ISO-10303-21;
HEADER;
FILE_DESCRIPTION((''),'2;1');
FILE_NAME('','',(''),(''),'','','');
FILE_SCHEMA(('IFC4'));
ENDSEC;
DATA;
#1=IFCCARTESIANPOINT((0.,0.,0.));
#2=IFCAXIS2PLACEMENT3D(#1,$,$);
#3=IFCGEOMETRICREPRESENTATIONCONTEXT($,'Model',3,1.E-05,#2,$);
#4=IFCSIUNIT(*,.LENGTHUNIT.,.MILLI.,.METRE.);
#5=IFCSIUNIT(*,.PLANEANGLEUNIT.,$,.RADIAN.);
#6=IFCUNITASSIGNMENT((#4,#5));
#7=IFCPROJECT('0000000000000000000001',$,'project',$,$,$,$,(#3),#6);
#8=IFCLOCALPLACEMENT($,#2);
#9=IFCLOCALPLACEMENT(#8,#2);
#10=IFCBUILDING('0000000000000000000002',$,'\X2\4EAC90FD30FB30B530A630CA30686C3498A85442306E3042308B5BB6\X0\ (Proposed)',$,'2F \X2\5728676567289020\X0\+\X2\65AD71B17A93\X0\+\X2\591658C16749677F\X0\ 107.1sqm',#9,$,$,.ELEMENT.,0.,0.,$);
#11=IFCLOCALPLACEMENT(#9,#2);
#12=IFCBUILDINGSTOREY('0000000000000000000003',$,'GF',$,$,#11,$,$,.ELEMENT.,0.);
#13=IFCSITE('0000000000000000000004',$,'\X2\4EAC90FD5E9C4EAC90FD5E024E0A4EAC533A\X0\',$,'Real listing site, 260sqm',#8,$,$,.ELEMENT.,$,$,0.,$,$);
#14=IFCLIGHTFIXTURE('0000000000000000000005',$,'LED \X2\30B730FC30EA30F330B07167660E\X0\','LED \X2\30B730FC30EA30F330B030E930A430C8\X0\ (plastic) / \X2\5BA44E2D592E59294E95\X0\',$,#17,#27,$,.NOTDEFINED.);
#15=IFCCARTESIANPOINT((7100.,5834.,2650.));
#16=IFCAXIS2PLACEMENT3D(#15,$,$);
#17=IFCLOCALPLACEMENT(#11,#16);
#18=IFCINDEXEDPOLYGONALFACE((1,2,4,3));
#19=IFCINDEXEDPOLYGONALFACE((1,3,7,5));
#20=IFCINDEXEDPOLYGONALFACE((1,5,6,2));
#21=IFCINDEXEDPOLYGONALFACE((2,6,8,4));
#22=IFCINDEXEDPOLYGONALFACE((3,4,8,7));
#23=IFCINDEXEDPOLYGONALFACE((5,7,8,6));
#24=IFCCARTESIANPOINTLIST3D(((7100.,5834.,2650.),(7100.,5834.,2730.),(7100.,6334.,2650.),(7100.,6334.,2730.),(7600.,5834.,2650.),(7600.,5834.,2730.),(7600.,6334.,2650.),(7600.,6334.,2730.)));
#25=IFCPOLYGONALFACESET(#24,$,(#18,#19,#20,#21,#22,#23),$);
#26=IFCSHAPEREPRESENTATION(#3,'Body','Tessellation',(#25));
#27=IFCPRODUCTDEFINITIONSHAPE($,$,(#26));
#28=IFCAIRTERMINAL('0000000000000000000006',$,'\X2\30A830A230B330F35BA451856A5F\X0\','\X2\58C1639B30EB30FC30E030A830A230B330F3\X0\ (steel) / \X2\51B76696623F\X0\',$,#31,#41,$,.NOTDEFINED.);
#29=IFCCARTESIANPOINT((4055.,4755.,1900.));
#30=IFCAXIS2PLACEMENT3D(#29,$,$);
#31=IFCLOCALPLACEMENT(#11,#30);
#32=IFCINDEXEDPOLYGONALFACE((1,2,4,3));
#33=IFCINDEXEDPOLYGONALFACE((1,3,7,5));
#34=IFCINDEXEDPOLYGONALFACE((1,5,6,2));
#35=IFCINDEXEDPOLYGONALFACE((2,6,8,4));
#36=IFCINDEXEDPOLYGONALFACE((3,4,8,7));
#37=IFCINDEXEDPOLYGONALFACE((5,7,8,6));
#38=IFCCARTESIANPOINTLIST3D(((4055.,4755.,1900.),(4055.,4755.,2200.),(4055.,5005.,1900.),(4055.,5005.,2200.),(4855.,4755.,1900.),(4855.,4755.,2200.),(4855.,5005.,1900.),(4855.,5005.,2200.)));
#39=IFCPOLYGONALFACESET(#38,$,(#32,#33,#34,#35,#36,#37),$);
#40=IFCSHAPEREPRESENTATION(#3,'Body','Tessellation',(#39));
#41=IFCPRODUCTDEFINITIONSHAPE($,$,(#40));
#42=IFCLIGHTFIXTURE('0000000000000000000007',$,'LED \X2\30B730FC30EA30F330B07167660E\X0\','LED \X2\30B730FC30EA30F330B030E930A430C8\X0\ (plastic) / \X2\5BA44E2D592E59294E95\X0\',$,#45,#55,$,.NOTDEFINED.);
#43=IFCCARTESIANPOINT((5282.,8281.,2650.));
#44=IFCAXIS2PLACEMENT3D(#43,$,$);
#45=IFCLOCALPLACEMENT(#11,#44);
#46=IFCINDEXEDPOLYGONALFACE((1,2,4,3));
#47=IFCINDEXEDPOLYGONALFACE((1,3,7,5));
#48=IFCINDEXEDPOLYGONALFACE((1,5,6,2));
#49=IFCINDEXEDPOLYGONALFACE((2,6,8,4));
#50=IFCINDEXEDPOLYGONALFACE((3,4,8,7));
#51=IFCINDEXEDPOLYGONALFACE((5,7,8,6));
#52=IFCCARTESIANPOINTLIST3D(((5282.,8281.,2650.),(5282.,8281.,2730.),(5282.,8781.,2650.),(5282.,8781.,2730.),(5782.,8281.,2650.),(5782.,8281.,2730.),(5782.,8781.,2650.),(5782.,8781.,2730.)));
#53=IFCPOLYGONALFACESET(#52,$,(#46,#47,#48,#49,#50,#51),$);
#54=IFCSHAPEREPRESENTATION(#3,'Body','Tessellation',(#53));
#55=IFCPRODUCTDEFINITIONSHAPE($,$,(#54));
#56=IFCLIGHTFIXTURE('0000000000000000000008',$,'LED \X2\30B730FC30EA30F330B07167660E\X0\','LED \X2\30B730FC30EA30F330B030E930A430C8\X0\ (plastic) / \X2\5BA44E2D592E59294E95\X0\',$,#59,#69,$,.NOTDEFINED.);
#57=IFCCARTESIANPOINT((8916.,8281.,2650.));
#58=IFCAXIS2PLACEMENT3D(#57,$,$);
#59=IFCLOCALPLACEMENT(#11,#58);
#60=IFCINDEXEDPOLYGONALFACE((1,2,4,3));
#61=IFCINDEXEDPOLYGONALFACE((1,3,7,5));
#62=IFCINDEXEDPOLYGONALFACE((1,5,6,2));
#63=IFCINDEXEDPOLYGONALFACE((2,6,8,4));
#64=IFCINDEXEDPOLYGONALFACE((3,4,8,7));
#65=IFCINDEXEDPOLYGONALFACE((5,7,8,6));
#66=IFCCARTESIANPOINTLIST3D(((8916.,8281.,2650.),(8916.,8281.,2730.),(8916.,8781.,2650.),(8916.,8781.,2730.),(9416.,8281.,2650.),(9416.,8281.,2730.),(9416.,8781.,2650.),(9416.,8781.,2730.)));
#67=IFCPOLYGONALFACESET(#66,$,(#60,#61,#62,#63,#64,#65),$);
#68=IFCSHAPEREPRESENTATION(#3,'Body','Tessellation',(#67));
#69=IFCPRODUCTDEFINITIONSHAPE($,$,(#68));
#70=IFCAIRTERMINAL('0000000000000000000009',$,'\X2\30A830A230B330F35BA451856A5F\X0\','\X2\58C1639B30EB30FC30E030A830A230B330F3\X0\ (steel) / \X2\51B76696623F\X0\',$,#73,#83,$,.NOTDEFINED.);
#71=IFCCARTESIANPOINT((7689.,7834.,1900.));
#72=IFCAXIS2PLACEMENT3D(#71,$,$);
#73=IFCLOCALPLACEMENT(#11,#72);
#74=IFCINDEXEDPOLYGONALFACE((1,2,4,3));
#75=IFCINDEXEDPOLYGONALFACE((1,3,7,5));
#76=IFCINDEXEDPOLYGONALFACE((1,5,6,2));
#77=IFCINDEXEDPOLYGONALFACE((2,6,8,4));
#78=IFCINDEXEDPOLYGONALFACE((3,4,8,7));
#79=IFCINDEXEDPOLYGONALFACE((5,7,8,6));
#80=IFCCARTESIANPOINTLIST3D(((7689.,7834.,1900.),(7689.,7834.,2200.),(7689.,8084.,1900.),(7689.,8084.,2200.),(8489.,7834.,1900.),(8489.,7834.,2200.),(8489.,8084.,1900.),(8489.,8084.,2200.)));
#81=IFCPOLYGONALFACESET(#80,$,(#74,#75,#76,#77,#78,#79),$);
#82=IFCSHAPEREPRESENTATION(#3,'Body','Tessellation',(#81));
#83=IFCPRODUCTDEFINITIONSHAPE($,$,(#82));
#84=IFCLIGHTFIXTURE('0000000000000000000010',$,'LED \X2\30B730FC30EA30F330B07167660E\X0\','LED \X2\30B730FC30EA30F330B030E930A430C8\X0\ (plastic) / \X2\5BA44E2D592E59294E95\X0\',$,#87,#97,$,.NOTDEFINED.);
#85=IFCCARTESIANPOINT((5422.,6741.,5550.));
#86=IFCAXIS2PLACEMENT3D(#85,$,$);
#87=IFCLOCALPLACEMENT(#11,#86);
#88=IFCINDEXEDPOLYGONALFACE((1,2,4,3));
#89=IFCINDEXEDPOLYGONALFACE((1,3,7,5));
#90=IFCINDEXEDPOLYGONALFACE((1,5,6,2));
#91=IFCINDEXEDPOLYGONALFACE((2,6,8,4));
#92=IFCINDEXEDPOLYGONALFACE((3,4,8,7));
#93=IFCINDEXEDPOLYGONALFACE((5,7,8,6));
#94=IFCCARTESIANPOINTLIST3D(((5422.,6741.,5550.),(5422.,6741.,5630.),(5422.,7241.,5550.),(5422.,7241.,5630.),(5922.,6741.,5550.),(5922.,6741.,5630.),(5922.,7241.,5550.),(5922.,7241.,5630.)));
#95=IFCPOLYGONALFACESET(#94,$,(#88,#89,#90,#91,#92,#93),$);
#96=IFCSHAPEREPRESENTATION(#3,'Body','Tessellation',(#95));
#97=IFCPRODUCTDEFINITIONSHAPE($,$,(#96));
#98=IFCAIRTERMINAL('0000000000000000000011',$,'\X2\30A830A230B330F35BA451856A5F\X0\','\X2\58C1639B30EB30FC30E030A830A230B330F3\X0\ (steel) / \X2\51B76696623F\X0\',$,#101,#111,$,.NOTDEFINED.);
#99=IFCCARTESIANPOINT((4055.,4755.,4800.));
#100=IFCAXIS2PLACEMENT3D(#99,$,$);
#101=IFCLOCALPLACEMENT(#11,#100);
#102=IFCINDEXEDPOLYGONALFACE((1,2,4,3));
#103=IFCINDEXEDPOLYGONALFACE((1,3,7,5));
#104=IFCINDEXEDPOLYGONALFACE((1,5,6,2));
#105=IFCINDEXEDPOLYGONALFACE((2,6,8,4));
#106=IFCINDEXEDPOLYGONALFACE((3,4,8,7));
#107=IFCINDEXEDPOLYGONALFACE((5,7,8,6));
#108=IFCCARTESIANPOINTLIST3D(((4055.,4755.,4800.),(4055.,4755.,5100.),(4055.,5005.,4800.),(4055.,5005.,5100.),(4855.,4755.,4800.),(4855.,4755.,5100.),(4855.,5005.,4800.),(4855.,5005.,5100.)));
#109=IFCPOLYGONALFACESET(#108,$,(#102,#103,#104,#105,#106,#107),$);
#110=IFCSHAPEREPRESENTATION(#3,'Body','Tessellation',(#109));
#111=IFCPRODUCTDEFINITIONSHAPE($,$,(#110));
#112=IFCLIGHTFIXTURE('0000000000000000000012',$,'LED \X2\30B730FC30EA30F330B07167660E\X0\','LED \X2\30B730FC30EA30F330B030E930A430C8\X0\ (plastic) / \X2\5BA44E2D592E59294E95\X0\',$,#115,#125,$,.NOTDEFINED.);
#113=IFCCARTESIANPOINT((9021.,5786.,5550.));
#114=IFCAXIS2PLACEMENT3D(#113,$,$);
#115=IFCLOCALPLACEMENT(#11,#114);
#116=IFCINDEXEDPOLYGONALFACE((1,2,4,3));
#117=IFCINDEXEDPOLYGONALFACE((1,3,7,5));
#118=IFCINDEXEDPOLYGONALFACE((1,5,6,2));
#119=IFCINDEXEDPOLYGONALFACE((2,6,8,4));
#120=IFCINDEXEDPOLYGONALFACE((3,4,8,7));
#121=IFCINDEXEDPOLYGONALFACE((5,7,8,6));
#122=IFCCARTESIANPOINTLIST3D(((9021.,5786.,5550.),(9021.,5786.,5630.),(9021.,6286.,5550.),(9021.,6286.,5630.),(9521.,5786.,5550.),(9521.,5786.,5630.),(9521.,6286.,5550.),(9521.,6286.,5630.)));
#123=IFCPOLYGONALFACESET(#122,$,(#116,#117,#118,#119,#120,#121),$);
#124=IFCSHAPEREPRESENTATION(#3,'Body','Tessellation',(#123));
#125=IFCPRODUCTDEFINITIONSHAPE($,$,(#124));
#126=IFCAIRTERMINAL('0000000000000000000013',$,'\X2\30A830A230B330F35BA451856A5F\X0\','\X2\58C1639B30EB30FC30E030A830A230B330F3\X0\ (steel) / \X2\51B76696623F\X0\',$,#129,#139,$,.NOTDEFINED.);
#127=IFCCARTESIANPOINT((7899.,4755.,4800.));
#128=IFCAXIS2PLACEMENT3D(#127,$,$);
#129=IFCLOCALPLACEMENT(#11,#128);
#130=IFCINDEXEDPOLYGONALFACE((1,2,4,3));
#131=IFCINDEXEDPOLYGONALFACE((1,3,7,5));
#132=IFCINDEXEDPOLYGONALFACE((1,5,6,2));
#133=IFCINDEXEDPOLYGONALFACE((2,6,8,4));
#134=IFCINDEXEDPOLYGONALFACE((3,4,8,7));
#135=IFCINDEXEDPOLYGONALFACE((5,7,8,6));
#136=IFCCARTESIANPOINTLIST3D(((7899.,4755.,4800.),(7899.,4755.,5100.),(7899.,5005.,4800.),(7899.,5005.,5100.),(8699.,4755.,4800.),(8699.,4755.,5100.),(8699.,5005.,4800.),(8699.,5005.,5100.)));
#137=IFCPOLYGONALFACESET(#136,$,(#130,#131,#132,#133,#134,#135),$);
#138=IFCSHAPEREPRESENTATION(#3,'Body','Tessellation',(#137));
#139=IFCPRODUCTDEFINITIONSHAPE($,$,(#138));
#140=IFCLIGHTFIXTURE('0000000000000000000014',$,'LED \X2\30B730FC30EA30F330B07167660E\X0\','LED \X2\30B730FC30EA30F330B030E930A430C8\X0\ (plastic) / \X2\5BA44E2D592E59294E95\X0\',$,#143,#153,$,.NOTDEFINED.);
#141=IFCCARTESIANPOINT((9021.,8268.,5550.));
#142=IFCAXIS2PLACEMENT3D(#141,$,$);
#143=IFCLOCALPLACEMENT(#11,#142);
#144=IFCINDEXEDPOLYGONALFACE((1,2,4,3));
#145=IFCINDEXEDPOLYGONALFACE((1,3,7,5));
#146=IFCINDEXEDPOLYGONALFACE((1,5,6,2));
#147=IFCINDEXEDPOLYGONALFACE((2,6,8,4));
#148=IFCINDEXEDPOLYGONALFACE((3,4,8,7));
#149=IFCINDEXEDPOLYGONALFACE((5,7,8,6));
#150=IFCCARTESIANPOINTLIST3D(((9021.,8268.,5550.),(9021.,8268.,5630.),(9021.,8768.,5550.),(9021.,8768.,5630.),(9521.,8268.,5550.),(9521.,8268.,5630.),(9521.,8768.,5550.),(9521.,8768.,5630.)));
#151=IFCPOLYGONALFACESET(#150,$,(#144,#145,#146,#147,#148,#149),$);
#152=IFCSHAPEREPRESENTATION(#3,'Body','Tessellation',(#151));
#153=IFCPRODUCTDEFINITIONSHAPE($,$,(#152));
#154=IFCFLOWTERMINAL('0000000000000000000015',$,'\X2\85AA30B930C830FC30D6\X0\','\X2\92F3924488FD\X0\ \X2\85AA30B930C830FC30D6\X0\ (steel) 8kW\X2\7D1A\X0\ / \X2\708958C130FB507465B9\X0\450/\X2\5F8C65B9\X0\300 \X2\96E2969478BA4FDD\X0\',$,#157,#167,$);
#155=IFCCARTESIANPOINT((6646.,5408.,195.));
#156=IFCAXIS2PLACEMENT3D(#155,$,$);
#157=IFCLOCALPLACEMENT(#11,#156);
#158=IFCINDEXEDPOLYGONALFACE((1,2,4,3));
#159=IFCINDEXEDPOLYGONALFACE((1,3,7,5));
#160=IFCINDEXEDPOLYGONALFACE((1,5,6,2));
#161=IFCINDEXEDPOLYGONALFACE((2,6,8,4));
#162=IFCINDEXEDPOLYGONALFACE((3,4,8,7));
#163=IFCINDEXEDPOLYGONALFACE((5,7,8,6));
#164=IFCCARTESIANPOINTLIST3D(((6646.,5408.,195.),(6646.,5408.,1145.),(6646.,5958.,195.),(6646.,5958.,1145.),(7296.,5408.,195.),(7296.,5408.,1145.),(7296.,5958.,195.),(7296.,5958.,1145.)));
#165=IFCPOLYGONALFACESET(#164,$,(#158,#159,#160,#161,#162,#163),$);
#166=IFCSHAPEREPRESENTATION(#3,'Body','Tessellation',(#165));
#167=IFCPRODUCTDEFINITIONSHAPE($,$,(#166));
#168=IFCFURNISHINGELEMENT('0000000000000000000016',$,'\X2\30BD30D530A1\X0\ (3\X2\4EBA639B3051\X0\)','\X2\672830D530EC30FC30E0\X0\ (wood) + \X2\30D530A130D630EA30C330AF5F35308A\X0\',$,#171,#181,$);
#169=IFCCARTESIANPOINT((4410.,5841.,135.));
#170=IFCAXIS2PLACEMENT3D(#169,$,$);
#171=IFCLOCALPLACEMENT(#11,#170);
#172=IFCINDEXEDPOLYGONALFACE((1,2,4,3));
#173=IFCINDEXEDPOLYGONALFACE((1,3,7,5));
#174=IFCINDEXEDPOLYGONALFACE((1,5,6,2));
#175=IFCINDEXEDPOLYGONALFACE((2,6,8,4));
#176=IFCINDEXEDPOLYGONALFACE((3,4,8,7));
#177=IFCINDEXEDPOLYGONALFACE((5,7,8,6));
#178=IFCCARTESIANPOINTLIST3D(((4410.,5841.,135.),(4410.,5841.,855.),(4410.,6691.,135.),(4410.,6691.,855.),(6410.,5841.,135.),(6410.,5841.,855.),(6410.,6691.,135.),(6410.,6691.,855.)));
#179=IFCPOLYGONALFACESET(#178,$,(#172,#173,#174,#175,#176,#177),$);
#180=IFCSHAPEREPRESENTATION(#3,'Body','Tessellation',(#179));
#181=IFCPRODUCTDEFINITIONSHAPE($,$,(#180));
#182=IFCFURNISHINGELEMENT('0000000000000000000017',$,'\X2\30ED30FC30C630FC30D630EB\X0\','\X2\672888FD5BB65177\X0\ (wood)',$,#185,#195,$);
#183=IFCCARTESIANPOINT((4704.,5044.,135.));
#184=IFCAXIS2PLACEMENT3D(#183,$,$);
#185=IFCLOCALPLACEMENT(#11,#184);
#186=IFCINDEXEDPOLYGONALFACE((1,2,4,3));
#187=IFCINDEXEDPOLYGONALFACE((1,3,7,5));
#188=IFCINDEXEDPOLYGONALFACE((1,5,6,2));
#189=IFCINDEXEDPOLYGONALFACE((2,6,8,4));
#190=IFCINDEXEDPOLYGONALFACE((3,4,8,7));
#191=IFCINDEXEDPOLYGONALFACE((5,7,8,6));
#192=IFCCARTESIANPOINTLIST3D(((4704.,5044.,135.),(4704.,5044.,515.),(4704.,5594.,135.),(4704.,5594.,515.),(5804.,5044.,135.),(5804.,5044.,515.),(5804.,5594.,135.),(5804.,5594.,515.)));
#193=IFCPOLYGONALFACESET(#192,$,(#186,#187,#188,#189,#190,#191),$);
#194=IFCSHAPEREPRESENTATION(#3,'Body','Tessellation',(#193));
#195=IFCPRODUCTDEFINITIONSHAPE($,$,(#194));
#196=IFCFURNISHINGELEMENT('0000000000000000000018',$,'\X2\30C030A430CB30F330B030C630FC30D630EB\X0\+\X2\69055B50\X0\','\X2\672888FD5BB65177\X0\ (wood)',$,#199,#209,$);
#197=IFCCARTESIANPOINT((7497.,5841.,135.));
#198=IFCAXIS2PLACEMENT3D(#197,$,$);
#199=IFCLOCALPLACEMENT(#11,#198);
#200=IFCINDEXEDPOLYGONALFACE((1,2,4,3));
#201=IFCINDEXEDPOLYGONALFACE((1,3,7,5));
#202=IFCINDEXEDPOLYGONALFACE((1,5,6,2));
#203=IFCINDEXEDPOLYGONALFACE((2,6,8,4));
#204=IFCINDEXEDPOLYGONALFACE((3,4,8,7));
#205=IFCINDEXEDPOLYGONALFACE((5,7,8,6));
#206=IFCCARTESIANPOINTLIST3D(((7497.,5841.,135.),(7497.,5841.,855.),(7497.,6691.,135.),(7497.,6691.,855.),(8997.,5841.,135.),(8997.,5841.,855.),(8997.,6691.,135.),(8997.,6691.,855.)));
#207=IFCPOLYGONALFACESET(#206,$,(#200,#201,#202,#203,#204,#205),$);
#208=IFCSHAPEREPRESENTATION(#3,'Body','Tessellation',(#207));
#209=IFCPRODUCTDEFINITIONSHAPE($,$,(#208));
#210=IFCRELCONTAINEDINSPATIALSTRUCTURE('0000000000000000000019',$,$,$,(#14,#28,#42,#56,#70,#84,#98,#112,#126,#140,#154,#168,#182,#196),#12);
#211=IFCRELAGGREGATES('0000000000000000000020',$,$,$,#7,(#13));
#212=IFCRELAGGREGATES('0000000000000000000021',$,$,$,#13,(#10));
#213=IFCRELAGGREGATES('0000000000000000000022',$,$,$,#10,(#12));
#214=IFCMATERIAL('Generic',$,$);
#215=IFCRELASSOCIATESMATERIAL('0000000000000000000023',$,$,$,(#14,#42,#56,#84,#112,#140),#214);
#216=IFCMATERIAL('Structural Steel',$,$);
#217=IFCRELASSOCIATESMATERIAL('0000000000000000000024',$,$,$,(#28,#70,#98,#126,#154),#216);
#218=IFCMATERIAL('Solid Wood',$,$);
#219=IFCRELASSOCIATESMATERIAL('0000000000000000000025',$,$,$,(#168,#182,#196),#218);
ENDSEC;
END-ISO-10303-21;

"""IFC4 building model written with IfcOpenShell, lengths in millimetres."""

from ifc_helpers import new_model, si_unit, frame, frame_2d, origin, place, context, project, spatial, rectangle, extrude, material, element, save


model = new_model("IFC4")

# Units and contexts
model_context = context("Model", 3, precision=1e-05, world=origin())
ifc_project = project(units=[si_unit("LENGTHUNIT", "METRE", prefix="MILLI"), si_unit("PLANEANGLEUNIT", "RADIAN")], contexts=[model_context])

# Site, building, storey
site_placement = place(None, origin())
site = spatial("IfcSite", under=ifc_project, at=site_placement, Name="京都府京都市上京区", ObjectType="Real listing site, 260sqm", CompositionType="ELEMENT", RefElevation=0.0)
building_placement = place(site_placement, origin())
building = spatial("IfcBuilding", under=site, at=building_placement, Name="京都・サウナと水風呂のある家 (Proposed)", ObjectType="2F 在来木造+断熱窓+外壁杉板 107.1sqm", CompositionType="ELEMENT", ElevationOfRefHeight=0.0, ElevationOfTerrain=0.0)
storey_placement = place(building_placement, origin())
storey = spatial("IfcBuildingStorey", under=building, at=storey_placement, Name="GF", CompositionType="ELEMENT", Elevation=0.0)

# Shared definitions
ifc_material_1 = material(Name="Solid Wood")

# Shared definitions
ifc_material_2 = material(Name="Structural Steel")

# Shared definitions
ifc_material_3 = material(Name="Generic")

# Light fixture
light_fixture_1_placement = place(storey_placement, frame((7100.0, 5834.0, 2650.0)))
element("IfcLightFixture", 1, at=light_fixture_1_placement, inside=storey, material=ifc_material_3, Name="LED シーリング照明", Description="LED シーリングライト (plastic) / 室中央天井", PredefinedType="NOTDEFINED", context=model_context, shape_type="SweptSolid", body=[
    extrude(rectangle(XDim=500.0, YDim=500.0, at=frame_2d((250.0, 250.0))), frame((7100.0, 5834.0, 2650.0)), (0.0, 0.0, 1.0), 80.0),
])

# Air terminal
air_terminal_1_placement = place(storey_placement, frame((4055.0, 4755.0, 1900.0)))
element("IfcAirTerminal", 2, at=air_terminal_1_placement, inside=storey, material=ifc_material_2, Name="エアコン室内機", Description="壁掛ルームエアコン (steel) / 冷暖房", PredefinedType="NOTDEFINED", context=model_context, shape_type="SweptSolid", body=[
    extrude(rectangle(XDim=800.0, YDim=250.0, at=frame_2d((400.0, 125.0))), frame((4055.0, 4755.0, 1900.0)), (0.0, 0.0, 1.0), 300.0),
])

# Light fixtures
light_fixture_2_placement = place(storey_placement, frame((5282.0, 8281.0, 2650.0)))
element("IfcLightFixture", 3, at=light_fixture_2_placement, inside=storey, material=ifc_material_3, Name="LED シーリング照明", Description="LED シーリングライト (plastic) / 室中央天井", PredefinedType="NOTDEFINED", context=model_context, shape_type="SweptSolid", body=[
    extrude(rectangle(XDim=500.0, YDim=500.0, at=frame_2d((250.0, 250.0))), frame((5282.0, 8281.0, 2650.0)), (0.0, 0.0, 1.0), 80.0),
])
light_fixture_3_placement = place(storey_placement, frame((8916.0, 8281.0, 2650.0)))
element("IfcLightFixture", 4, at=light_fixture_3_placement, inside=storey, material=ifc_material_3, Name="LED シーリング照明", Description="LED シーリングライト (plastic) / 室中央天井", PredefinedType="NOTDEFINED", context=model_context, shape_type="SweptSolid", body=[
    extrude(rectangle(XDim=500.0, YDim=500.0, at=frame_2d((250.0, 250.0))), frame((8916.0, 8281.0, 2650.0)), (0.0, 0.0, 1.0), 80.0),
])

# Air terminal
air_terminal_2_placement = place(storey_placement, frame((7689.0, 7834.0, 1900.0)))
element("IfcAirTerminal", 5, at=air_terminal_2_placement, inside=storey, material=ifc_material_2, Name="エアコン室内機", Description="壁掛ルームエアコン (steel) / 冷暖房", PredefinedType="NOTDEFINED", context=model_context, shape_type="SweptSolid", body=[
    extrude(rectangle(XDim=800.0, YDim=250.0, at=frame_2d((400.0, 125.0))), frame((7689.0, 7834.0, 1900.0)), (0.0, 0.0, 1.0), 300.0),
])

# Light fixture
light_fixture_4_placement = place(storey_placement, frame((5422.0, 6741.0, 5550.0)))
element("IfcLightFixture", 6, at=light_fixture_4_placement, inside=storey, material=ifc_material_3, Name="LED シーリング照明", Description="LED シーリングライト (plastic) / 室中央天井", PredefinedType="NOTDEFINED", context=model_context, shape_type="SweptSolid", body=[
    extrude(rectangle(XDim=500.0, YDim=500.0, at=frame_2d((250.0, 250.0))), frame((5422.0, 6741.0, 5550.0)), (0.0, 0.0, 1.0), 80.0),
])

# Air terminal
air_terminal_3_placement = place(storey_placement, frame((4055.0, 4755.0, 4800.0)))
element("IfcAirTerminal", 7, at=air_terminal_3_placement, inside=storey, material=ifc_material_2, Name="エアコン室内機", Description="壁掛ルームエアコン (steel) / 冷暖房", PredefinedType="NOTDEFINED", context=model_context, shape_type="SweptSolid", body=[
    extrude(rectangle(XDim=800.0, YDim=250.0, at=frame_2d((400.0, 125.0))), frame((4055.0, 4755.0, 4800.0)), (0.0, 0.0, 1.0), 300.0),
])

# Light fixture
light_fixture_5_placement = place(storey_placement, frame((9021.0, 5786.0, 5550.0)))
element("IfcLightFixture", 8, at=light_fixture_5_placement, inside=storey, material=ifc_material_3, Name="LED シーリング照明", Description="LED シーリングライト (plastic) / 室中央天井", PredefinedType="NOTDEFINED", context=model_context, shape_type="SweptSolid", body=[
    extrude(rectangle(XDim=500.0, YDim=500.0, at=frame_2d((250.0, 250.0))), frame((9021.0, 5786.0, 5550.0)), (0.0, 0.0, 1.0), 80.0),
])

# Air terminal
air_terminal_4_placement = place(storey_placement, frame((7899.0, 4755.0, 4800.0)))
element("IfcAirTerminal", 9, at=air_terminal_4_placement, inside=storey, material=ifc_material_2, Name="エアコン室内機", Description="壁掛ルームエアコン (steel) / 冷暖房", PredefinedType="NOTDEFINED", context=model_context, shape_type="SweptSolid", body=[
    extrude(rectangle(XDim=800.0, YDim=250.0, at=frame_2d((400.0, 125.0))), frame((7899.0, 4755.0, 4800.0)), (0.0, 0.0, 1.0), 300.0),
])

# Light fixture
light_fixture_6_placement = place(storey_placement, frame((9021.0, 8268.0, 5550.0)))
element("IfcLightFixture", 10, at=light_fixture_6_placement, inside=storey, material=ifc_material_3, Name="LED シーリング照明", Description="LED シーリングライト (plastic) / 室中央天井", PredefinedType="NOTDEFINED", context=model_context, shape_type="SweptSolid", body=[
    extrude(rectangle(XDim=500.0, YDim=500.0, at=frame_2d((250.0, 250.0))), frame((9021.0, 8268.0, 5550.0)), (0.0, 0.0, 1.0), 80.0),
])

# Flow terminal
flow_terminal_1_placement = place(storey_placement, frame((6646.0, 5408.0, 195.0)))
element("IfcFlowTerminal", 11, at=flow_terminal_1_placement, inside=storey, material=ifc_material_2, Name="薪ストーブ", Description="鋳鉄製 薪ストーブ (steel) 8kW級 / 炉壁・側方450/後方300 離隔確保", context=model_context, shape_type="SweptSolid", body=[
    extrude(rectangle(XDim=650.0, YDim=550.0, at=frame_2d((325.0, 275.0))), frame((6646.0, 5408.0, 195.0)), (0.0, 0.0, 1.0), 950.0),
])

# Furnishing elements
furnishing_1_placement = place(storey_placement, frame((4410.0, 5841.0, 135.0)))
element("IfcFurnishingElement", 12, at=furnishing_1_placement, inside=storey, material=ifc_material_1, Name="ソファ (3人掛け)", Description="木フレーム (wood) + ファブリック張り", context=model_context, shape_type="SweptSolid", body=[
    extrude(rectangle(XDim=2000.0, YDim=850.0, at=frame_2d((1000.0, 425.0))), frame((4410.0, 5841.0, 135.0)), (0.0, 0.0, 1.0), 720.0),
])
furnishing_2_placement = place(storey_placement, frame((4704.0, 5044.0, 135.0)))
element("IfcFurnishingElement", 13, at=furnishing_2_placement, inside=storey, material=ifc_material_1, Name="ローテーブル", Description="木製家具 (wood)", context=model_context, shape_type="SweptSolid", body=[
    extrude(rectangle(XDim=1100.0, YDim=550.0, at=frame_2d((550.0, 275.0))), frame((4704.0, 5044.0, 135.0)), (0.0, 0.0, 1.0), 380.0),
])
furnishing_3_placement = place(storey_placement, frame((7497.0, 5841.0, 135.0)))
element("IfcFurnishingElement", 14, at=furnishing_3_placement, inside=storey, material=ifc_material_1, Name="ダイニングテーブル+椅子", Description="木製家具 (wood)", context=model_context, shape_type="SweptSolid", body=[
    extrude(rectangle(XDim=1500.0, YDim=850.0, at=frame_2d((750.0, 425.0))), frame((7497.0, 5841.0, 135.0)), (0.0, 0.0, 1.0), 720.0),
])

save(model, "model.ifc")
